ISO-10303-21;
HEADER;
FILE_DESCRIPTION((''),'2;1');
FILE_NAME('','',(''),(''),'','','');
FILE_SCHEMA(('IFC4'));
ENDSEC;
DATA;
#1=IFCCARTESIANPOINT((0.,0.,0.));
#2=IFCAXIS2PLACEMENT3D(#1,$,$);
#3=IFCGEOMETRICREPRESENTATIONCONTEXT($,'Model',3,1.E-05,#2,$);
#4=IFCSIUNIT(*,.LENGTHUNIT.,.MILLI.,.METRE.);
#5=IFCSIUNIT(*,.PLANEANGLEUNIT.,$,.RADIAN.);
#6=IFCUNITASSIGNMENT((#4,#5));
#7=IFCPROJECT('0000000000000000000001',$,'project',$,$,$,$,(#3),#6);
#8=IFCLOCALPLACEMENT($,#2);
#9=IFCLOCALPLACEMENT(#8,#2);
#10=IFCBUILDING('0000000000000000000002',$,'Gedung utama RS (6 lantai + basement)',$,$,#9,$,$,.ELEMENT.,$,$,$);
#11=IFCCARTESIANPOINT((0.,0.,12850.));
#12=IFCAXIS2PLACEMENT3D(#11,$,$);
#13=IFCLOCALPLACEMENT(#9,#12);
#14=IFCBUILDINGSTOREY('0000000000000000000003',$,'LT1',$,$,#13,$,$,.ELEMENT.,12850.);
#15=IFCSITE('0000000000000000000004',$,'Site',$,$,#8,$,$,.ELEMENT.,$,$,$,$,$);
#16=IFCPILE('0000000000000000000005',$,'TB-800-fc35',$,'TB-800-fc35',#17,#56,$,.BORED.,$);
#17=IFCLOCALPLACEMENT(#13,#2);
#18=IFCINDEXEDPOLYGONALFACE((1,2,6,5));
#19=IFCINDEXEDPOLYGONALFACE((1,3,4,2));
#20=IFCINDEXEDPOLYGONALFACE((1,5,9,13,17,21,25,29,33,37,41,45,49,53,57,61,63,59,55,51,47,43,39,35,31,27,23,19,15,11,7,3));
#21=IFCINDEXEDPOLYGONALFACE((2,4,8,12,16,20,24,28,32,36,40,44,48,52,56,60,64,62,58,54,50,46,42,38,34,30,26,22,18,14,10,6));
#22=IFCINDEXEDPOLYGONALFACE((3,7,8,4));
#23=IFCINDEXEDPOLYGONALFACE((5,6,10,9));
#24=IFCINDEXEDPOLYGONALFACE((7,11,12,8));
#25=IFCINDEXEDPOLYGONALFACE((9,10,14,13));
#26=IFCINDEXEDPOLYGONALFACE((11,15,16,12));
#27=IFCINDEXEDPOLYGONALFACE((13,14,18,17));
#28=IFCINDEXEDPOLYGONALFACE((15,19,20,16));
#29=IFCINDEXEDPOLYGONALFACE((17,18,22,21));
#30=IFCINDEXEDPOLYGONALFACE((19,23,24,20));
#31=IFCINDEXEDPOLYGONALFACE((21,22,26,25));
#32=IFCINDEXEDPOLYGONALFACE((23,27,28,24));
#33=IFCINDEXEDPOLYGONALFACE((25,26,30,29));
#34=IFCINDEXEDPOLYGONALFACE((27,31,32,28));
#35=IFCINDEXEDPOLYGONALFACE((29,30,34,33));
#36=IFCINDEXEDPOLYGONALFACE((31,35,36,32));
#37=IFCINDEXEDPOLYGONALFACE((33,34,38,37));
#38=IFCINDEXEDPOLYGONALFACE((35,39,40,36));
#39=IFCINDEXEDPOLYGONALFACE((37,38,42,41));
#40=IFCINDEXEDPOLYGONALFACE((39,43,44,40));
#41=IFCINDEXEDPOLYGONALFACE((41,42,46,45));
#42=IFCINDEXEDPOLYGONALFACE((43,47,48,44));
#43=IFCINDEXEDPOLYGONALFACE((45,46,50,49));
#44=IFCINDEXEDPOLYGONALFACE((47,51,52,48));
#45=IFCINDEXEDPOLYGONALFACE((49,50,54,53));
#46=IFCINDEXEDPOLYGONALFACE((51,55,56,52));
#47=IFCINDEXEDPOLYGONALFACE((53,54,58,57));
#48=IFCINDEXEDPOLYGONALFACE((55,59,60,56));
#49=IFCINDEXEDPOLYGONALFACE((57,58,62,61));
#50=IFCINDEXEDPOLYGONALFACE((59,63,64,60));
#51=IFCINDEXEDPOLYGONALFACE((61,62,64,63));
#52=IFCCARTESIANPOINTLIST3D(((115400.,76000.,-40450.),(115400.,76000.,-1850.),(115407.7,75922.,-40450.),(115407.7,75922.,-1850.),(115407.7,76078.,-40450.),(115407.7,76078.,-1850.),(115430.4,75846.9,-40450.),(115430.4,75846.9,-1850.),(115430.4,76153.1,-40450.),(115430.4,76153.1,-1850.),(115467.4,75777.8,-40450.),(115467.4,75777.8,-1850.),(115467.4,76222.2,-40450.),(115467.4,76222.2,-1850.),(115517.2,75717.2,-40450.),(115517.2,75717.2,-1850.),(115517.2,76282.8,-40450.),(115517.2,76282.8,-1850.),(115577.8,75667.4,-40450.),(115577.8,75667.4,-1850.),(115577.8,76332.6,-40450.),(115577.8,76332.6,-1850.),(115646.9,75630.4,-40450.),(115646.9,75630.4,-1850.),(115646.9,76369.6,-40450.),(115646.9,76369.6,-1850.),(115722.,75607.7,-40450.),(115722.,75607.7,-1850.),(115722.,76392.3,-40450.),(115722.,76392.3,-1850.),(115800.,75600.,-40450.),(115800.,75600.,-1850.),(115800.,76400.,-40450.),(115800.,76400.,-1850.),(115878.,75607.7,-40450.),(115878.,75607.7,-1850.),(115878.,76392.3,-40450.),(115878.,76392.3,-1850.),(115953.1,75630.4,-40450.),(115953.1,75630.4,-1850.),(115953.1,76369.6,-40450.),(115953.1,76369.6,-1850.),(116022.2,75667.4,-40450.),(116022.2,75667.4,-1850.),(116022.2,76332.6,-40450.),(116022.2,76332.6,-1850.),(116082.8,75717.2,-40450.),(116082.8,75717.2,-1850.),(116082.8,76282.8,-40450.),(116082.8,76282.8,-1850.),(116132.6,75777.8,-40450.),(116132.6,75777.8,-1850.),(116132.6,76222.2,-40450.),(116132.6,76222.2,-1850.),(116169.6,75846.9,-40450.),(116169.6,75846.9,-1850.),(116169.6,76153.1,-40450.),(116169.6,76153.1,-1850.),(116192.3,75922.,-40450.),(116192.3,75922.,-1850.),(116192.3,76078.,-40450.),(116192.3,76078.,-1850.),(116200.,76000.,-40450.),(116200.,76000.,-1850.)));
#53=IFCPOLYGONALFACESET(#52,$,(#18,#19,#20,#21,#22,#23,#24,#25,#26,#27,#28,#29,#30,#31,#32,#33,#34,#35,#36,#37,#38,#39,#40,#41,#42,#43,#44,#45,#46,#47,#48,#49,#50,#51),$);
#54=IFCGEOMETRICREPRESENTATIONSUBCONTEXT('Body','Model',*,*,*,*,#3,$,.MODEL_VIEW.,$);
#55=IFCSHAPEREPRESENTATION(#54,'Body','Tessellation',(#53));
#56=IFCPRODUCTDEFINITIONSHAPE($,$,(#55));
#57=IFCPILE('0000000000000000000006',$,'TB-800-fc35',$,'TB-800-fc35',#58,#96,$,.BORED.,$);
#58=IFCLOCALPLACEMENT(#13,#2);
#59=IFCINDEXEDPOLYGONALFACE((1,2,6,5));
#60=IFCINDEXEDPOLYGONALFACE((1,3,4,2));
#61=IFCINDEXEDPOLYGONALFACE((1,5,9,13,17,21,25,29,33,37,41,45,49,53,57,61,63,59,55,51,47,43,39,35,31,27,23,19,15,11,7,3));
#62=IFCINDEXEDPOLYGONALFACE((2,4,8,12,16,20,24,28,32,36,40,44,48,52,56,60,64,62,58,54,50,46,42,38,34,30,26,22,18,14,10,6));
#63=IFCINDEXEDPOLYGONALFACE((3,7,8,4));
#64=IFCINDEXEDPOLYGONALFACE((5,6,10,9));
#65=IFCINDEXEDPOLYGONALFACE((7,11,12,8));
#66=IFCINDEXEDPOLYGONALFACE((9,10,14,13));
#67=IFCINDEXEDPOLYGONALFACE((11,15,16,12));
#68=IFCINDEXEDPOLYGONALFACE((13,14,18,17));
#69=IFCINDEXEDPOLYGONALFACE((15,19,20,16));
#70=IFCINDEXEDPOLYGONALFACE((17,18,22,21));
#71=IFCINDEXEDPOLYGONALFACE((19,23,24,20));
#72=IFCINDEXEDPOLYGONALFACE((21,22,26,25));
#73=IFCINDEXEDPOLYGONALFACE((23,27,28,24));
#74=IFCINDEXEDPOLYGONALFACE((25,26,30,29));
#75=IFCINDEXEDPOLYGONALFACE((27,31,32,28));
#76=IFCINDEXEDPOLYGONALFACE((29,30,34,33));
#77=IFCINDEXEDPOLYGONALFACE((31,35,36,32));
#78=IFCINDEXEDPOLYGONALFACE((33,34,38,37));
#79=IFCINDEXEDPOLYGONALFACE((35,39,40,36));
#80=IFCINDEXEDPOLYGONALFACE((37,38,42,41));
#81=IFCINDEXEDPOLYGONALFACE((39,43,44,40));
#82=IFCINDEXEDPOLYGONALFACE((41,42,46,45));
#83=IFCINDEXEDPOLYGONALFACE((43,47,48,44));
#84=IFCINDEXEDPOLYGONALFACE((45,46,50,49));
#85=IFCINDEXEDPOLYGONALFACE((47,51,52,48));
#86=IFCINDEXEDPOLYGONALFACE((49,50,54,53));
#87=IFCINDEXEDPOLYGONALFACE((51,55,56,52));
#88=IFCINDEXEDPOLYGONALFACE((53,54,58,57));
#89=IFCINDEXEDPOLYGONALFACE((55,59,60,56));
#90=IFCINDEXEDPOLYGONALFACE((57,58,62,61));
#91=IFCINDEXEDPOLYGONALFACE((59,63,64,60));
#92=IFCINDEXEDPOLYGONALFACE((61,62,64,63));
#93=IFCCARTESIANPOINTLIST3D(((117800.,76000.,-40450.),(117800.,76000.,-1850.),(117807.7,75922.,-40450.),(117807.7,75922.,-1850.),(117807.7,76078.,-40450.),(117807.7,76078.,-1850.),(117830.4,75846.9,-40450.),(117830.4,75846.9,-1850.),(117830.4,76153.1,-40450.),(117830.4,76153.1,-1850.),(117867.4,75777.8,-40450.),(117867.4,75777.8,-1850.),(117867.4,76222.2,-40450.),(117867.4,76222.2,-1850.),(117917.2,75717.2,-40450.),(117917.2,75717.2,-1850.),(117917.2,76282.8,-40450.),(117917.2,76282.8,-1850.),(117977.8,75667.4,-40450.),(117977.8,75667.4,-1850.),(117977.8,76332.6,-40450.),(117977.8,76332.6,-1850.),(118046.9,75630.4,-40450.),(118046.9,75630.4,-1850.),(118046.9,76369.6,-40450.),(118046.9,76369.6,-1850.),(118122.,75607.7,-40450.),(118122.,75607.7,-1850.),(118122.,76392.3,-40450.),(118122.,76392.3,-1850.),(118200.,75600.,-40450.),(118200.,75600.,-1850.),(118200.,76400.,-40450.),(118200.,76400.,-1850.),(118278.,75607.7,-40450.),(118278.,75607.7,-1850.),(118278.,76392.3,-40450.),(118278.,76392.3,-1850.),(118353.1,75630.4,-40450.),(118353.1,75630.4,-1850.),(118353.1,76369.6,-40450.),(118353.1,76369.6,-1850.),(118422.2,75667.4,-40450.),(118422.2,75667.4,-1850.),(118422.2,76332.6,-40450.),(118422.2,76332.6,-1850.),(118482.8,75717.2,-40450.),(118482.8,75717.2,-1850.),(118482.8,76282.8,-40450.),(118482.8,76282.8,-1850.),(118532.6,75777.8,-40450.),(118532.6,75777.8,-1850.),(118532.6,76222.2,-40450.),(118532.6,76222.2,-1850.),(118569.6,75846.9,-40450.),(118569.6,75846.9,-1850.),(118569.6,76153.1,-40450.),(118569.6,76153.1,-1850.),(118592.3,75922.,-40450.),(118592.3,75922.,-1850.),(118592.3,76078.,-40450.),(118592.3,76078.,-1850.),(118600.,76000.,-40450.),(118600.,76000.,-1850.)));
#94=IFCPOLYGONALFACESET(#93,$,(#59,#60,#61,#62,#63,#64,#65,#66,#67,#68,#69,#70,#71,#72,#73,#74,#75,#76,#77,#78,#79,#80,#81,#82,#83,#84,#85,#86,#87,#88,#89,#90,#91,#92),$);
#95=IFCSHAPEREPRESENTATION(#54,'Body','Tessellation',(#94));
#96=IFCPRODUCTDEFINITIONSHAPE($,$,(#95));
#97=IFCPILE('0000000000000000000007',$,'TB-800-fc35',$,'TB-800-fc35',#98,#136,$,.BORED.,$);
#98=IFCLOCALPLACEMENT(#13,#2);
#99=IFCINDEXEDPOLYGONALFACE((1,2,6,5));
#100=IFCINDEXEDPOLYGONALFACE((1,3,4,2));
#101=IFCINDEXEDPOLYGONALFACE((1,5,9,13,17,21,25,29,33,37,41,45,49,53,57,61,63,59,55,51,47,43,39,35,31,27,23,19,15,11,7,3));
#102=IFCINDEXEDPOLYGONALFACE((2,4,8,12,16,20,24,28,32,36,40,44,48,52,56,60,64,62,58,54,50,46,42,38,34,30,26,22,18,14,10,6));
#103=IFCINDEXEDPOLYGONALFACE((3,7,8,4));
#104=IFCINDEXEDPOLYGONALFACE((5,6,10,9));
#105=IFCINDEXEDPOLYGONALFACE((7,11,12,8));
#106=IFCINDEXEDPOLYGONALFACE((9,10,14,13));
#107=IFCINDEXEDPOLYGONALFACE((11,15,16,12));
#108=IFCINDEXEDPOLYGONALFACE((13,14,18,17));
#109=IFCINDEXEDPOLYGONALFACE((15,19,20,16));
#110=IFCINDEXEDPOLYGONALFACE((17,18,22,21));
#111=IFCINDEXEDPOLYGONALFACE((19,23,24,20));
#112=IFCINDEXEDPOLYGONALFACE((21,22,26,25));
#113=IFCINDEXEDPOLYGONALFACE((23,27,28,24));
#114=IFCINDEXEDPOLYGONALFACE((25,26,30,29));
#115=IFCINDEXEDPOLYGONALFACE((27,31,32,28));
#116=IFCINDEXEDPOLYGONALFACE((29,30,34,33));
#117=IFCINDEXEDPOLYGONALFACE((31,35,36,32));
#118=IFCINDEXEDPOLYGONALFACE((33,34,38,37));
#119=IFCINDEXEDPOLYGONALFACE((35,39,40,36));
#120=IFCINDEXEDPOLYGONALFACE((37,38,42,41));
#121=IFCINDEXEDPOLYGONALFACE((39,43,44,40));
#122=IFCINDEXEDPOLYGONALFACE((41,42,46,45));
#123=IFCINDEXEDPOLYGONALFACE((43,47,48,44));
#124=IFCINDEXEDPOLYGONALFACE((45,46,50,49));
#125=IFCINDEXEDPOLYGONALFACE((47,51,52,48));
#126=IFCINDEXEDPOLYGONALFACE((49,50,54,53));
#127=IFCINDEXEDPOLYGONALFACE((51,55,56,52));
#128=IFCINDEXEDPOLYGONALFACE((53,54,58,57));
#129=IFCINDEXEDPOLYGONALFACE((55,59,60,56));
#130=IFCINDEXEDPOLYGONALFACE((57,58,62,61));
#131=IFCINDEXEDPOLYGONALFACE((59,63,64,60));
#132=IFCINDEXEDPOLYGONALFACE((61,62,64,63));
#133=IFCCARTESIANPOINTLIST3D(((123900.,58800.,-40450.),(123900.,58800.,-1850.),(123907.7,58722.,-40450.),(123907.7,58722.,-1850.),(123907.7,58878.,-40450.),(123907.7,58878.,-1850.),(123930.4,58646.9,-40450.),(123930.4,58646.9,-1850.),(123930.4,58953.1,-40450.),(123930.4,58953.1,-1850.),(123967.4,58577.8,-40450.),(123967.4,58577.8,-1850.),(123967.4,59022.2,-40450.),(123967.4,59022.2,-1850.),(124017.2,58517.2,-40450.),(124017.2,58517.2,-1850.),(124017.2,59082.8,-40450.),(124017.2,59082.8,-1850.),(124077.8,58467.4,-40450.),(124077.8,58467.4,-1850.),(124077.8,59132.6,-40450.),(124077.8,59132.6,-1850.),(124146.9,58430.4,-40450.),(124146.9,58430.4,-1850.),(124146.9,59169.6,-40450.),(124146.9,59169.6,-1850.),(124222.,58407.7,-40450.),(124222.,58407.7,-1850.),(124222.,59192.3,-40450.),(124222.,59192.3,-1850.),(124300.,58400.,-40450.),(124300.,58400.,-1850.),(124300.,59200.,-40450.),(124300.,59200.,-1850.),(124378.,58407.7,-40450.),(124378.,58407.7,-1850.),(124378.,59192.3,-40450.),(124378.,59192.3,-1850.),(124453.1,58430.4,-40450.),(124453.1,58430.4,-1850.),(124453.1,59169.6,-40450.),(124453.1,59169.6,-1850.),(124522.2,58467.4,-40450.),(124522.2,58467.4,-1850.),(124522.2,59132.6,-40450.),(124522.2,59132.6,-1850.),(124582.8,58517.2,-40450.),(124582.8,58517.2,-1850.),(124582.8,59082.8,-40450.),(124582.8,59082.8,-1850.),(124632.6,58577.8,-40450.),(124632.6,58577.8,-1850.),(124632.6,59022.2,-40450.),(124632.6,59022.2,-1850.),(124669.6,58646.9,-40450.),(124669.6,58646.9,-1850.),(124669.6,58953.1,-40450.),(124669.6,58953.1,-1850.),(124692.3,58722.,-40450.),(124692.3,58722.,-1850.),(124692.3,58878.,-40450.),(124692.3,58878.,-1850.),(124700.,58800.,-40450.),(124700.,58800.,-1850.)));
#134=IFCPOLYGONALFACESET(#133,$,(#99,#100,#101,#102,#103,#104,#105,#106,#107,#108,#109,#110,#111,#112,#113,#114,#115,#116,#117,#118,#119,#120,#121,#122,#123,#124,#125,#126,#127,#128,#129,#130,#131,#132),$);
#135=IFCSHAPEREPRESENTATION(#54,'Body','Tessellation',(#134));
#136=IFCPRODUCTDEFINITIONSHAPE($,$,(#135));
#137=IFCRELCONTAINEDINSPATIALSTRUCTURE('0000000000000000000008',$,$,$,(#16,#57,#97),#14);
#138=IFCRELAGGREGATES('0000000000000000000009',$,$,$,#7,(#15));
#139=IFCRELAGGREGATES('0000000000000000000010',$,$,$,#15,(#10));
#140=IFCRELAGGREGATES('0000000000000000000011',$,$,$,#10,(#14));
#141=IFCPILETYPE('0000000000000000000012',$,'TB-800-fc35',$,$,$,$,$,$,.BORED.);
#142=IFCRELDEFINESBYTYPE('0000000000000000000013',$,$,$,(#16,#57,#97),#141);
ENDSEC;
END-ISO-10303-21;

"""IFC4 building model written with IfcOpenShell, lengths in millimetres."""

from ifc_helpers import new_model, si_unit, frame, origin, origin_2d, place, context, subcontext, project, spatial, circle, extrude, material_profile, profile_set, profile_usage, type_object, element, save


model = new_model("IFC4")

# Units and contexts
model_context = context("Model", 3, precision=1e-05, world=origin())
body_context = subcontext(model_context, "Body", "Model", "MODEL_VIEW")
ifc_project = project(units=[si_unit("LENGTHUNIT", "METRE", prefix="MILLI"), si_unit("PLANEANGLEUNIT", "RADIAN")], contexts=[model_context])

# Site, building, storey
site_placement = place(None, origin())
site = spatial("IfcSite", under=ifc_project, at=site_placement, Name="Site", CompositionType="ELEMENT")
building_placement = place(site_placement, origin())
building = spatial("IfcBuilding", under=site, at=building_placement, Name="Gedung utama RS (6 lantai + basement)", CompositionType="ELEMENT")
storey_placement = place(building_placement, frame((0.0, 0.0, 12850.0)))
storey = spatial("IfcBuildingStorey", under=building, at=storey_placement, Name="LT1", CompositionType="ELEMENT", Elevation=12850.0)

# Piles
ifc_material_profile = material_profile(None, circle(Radius=400.0, at=origin_2d()), Name="TB-800-fc35")
ifc_profile_set = profile_set([ifc_material_profile], Name="TB-800-fc35")
ifc_profile_usage = profile_usage(ifc_profile_set, cardinal=5)
pile_type = type_object("IfcPileType", Name="TB-800-fc35", PredefinedType="BORED", material=ifc_profile_set)
for number, where, z_axis, x_axis, name in (
    (1, (115800.0, 76000.0, -40450.0), (0.0, 0.0, 1.0), (1.0, 0.0, 0.0), "TB-800-fc35"),
    (2, (118200.0, 76000.0, -40450.0), (0.0, 0.0, 1.0), (1.0, 0.0, 0.0), "TB-800-fc35"),
    (3, (124300.0, 58800.0, -40450.0), (0.0, 0.0, 1.0), (1.0, 0.0, 0.0), "TB-800-fc35"),
):
    element("IfcPile", number, at=place(storey_placement, frame(where, z_axis=z_axis, x_axis=x_axis)), inside=storey, type_object=pile_type, material=ifc_profile_usage, Name=name, ObjectType="TB-800-fc35", PredefinedType="BORED", context=body_context, shape_type="SweptSolid", body=[
        extrude(circle(Radius=400.0, at=origin_2d()), origin(), (0.0, 0.0, 1.0), 38600.0),
    ])

save(model, "model.ifc")
